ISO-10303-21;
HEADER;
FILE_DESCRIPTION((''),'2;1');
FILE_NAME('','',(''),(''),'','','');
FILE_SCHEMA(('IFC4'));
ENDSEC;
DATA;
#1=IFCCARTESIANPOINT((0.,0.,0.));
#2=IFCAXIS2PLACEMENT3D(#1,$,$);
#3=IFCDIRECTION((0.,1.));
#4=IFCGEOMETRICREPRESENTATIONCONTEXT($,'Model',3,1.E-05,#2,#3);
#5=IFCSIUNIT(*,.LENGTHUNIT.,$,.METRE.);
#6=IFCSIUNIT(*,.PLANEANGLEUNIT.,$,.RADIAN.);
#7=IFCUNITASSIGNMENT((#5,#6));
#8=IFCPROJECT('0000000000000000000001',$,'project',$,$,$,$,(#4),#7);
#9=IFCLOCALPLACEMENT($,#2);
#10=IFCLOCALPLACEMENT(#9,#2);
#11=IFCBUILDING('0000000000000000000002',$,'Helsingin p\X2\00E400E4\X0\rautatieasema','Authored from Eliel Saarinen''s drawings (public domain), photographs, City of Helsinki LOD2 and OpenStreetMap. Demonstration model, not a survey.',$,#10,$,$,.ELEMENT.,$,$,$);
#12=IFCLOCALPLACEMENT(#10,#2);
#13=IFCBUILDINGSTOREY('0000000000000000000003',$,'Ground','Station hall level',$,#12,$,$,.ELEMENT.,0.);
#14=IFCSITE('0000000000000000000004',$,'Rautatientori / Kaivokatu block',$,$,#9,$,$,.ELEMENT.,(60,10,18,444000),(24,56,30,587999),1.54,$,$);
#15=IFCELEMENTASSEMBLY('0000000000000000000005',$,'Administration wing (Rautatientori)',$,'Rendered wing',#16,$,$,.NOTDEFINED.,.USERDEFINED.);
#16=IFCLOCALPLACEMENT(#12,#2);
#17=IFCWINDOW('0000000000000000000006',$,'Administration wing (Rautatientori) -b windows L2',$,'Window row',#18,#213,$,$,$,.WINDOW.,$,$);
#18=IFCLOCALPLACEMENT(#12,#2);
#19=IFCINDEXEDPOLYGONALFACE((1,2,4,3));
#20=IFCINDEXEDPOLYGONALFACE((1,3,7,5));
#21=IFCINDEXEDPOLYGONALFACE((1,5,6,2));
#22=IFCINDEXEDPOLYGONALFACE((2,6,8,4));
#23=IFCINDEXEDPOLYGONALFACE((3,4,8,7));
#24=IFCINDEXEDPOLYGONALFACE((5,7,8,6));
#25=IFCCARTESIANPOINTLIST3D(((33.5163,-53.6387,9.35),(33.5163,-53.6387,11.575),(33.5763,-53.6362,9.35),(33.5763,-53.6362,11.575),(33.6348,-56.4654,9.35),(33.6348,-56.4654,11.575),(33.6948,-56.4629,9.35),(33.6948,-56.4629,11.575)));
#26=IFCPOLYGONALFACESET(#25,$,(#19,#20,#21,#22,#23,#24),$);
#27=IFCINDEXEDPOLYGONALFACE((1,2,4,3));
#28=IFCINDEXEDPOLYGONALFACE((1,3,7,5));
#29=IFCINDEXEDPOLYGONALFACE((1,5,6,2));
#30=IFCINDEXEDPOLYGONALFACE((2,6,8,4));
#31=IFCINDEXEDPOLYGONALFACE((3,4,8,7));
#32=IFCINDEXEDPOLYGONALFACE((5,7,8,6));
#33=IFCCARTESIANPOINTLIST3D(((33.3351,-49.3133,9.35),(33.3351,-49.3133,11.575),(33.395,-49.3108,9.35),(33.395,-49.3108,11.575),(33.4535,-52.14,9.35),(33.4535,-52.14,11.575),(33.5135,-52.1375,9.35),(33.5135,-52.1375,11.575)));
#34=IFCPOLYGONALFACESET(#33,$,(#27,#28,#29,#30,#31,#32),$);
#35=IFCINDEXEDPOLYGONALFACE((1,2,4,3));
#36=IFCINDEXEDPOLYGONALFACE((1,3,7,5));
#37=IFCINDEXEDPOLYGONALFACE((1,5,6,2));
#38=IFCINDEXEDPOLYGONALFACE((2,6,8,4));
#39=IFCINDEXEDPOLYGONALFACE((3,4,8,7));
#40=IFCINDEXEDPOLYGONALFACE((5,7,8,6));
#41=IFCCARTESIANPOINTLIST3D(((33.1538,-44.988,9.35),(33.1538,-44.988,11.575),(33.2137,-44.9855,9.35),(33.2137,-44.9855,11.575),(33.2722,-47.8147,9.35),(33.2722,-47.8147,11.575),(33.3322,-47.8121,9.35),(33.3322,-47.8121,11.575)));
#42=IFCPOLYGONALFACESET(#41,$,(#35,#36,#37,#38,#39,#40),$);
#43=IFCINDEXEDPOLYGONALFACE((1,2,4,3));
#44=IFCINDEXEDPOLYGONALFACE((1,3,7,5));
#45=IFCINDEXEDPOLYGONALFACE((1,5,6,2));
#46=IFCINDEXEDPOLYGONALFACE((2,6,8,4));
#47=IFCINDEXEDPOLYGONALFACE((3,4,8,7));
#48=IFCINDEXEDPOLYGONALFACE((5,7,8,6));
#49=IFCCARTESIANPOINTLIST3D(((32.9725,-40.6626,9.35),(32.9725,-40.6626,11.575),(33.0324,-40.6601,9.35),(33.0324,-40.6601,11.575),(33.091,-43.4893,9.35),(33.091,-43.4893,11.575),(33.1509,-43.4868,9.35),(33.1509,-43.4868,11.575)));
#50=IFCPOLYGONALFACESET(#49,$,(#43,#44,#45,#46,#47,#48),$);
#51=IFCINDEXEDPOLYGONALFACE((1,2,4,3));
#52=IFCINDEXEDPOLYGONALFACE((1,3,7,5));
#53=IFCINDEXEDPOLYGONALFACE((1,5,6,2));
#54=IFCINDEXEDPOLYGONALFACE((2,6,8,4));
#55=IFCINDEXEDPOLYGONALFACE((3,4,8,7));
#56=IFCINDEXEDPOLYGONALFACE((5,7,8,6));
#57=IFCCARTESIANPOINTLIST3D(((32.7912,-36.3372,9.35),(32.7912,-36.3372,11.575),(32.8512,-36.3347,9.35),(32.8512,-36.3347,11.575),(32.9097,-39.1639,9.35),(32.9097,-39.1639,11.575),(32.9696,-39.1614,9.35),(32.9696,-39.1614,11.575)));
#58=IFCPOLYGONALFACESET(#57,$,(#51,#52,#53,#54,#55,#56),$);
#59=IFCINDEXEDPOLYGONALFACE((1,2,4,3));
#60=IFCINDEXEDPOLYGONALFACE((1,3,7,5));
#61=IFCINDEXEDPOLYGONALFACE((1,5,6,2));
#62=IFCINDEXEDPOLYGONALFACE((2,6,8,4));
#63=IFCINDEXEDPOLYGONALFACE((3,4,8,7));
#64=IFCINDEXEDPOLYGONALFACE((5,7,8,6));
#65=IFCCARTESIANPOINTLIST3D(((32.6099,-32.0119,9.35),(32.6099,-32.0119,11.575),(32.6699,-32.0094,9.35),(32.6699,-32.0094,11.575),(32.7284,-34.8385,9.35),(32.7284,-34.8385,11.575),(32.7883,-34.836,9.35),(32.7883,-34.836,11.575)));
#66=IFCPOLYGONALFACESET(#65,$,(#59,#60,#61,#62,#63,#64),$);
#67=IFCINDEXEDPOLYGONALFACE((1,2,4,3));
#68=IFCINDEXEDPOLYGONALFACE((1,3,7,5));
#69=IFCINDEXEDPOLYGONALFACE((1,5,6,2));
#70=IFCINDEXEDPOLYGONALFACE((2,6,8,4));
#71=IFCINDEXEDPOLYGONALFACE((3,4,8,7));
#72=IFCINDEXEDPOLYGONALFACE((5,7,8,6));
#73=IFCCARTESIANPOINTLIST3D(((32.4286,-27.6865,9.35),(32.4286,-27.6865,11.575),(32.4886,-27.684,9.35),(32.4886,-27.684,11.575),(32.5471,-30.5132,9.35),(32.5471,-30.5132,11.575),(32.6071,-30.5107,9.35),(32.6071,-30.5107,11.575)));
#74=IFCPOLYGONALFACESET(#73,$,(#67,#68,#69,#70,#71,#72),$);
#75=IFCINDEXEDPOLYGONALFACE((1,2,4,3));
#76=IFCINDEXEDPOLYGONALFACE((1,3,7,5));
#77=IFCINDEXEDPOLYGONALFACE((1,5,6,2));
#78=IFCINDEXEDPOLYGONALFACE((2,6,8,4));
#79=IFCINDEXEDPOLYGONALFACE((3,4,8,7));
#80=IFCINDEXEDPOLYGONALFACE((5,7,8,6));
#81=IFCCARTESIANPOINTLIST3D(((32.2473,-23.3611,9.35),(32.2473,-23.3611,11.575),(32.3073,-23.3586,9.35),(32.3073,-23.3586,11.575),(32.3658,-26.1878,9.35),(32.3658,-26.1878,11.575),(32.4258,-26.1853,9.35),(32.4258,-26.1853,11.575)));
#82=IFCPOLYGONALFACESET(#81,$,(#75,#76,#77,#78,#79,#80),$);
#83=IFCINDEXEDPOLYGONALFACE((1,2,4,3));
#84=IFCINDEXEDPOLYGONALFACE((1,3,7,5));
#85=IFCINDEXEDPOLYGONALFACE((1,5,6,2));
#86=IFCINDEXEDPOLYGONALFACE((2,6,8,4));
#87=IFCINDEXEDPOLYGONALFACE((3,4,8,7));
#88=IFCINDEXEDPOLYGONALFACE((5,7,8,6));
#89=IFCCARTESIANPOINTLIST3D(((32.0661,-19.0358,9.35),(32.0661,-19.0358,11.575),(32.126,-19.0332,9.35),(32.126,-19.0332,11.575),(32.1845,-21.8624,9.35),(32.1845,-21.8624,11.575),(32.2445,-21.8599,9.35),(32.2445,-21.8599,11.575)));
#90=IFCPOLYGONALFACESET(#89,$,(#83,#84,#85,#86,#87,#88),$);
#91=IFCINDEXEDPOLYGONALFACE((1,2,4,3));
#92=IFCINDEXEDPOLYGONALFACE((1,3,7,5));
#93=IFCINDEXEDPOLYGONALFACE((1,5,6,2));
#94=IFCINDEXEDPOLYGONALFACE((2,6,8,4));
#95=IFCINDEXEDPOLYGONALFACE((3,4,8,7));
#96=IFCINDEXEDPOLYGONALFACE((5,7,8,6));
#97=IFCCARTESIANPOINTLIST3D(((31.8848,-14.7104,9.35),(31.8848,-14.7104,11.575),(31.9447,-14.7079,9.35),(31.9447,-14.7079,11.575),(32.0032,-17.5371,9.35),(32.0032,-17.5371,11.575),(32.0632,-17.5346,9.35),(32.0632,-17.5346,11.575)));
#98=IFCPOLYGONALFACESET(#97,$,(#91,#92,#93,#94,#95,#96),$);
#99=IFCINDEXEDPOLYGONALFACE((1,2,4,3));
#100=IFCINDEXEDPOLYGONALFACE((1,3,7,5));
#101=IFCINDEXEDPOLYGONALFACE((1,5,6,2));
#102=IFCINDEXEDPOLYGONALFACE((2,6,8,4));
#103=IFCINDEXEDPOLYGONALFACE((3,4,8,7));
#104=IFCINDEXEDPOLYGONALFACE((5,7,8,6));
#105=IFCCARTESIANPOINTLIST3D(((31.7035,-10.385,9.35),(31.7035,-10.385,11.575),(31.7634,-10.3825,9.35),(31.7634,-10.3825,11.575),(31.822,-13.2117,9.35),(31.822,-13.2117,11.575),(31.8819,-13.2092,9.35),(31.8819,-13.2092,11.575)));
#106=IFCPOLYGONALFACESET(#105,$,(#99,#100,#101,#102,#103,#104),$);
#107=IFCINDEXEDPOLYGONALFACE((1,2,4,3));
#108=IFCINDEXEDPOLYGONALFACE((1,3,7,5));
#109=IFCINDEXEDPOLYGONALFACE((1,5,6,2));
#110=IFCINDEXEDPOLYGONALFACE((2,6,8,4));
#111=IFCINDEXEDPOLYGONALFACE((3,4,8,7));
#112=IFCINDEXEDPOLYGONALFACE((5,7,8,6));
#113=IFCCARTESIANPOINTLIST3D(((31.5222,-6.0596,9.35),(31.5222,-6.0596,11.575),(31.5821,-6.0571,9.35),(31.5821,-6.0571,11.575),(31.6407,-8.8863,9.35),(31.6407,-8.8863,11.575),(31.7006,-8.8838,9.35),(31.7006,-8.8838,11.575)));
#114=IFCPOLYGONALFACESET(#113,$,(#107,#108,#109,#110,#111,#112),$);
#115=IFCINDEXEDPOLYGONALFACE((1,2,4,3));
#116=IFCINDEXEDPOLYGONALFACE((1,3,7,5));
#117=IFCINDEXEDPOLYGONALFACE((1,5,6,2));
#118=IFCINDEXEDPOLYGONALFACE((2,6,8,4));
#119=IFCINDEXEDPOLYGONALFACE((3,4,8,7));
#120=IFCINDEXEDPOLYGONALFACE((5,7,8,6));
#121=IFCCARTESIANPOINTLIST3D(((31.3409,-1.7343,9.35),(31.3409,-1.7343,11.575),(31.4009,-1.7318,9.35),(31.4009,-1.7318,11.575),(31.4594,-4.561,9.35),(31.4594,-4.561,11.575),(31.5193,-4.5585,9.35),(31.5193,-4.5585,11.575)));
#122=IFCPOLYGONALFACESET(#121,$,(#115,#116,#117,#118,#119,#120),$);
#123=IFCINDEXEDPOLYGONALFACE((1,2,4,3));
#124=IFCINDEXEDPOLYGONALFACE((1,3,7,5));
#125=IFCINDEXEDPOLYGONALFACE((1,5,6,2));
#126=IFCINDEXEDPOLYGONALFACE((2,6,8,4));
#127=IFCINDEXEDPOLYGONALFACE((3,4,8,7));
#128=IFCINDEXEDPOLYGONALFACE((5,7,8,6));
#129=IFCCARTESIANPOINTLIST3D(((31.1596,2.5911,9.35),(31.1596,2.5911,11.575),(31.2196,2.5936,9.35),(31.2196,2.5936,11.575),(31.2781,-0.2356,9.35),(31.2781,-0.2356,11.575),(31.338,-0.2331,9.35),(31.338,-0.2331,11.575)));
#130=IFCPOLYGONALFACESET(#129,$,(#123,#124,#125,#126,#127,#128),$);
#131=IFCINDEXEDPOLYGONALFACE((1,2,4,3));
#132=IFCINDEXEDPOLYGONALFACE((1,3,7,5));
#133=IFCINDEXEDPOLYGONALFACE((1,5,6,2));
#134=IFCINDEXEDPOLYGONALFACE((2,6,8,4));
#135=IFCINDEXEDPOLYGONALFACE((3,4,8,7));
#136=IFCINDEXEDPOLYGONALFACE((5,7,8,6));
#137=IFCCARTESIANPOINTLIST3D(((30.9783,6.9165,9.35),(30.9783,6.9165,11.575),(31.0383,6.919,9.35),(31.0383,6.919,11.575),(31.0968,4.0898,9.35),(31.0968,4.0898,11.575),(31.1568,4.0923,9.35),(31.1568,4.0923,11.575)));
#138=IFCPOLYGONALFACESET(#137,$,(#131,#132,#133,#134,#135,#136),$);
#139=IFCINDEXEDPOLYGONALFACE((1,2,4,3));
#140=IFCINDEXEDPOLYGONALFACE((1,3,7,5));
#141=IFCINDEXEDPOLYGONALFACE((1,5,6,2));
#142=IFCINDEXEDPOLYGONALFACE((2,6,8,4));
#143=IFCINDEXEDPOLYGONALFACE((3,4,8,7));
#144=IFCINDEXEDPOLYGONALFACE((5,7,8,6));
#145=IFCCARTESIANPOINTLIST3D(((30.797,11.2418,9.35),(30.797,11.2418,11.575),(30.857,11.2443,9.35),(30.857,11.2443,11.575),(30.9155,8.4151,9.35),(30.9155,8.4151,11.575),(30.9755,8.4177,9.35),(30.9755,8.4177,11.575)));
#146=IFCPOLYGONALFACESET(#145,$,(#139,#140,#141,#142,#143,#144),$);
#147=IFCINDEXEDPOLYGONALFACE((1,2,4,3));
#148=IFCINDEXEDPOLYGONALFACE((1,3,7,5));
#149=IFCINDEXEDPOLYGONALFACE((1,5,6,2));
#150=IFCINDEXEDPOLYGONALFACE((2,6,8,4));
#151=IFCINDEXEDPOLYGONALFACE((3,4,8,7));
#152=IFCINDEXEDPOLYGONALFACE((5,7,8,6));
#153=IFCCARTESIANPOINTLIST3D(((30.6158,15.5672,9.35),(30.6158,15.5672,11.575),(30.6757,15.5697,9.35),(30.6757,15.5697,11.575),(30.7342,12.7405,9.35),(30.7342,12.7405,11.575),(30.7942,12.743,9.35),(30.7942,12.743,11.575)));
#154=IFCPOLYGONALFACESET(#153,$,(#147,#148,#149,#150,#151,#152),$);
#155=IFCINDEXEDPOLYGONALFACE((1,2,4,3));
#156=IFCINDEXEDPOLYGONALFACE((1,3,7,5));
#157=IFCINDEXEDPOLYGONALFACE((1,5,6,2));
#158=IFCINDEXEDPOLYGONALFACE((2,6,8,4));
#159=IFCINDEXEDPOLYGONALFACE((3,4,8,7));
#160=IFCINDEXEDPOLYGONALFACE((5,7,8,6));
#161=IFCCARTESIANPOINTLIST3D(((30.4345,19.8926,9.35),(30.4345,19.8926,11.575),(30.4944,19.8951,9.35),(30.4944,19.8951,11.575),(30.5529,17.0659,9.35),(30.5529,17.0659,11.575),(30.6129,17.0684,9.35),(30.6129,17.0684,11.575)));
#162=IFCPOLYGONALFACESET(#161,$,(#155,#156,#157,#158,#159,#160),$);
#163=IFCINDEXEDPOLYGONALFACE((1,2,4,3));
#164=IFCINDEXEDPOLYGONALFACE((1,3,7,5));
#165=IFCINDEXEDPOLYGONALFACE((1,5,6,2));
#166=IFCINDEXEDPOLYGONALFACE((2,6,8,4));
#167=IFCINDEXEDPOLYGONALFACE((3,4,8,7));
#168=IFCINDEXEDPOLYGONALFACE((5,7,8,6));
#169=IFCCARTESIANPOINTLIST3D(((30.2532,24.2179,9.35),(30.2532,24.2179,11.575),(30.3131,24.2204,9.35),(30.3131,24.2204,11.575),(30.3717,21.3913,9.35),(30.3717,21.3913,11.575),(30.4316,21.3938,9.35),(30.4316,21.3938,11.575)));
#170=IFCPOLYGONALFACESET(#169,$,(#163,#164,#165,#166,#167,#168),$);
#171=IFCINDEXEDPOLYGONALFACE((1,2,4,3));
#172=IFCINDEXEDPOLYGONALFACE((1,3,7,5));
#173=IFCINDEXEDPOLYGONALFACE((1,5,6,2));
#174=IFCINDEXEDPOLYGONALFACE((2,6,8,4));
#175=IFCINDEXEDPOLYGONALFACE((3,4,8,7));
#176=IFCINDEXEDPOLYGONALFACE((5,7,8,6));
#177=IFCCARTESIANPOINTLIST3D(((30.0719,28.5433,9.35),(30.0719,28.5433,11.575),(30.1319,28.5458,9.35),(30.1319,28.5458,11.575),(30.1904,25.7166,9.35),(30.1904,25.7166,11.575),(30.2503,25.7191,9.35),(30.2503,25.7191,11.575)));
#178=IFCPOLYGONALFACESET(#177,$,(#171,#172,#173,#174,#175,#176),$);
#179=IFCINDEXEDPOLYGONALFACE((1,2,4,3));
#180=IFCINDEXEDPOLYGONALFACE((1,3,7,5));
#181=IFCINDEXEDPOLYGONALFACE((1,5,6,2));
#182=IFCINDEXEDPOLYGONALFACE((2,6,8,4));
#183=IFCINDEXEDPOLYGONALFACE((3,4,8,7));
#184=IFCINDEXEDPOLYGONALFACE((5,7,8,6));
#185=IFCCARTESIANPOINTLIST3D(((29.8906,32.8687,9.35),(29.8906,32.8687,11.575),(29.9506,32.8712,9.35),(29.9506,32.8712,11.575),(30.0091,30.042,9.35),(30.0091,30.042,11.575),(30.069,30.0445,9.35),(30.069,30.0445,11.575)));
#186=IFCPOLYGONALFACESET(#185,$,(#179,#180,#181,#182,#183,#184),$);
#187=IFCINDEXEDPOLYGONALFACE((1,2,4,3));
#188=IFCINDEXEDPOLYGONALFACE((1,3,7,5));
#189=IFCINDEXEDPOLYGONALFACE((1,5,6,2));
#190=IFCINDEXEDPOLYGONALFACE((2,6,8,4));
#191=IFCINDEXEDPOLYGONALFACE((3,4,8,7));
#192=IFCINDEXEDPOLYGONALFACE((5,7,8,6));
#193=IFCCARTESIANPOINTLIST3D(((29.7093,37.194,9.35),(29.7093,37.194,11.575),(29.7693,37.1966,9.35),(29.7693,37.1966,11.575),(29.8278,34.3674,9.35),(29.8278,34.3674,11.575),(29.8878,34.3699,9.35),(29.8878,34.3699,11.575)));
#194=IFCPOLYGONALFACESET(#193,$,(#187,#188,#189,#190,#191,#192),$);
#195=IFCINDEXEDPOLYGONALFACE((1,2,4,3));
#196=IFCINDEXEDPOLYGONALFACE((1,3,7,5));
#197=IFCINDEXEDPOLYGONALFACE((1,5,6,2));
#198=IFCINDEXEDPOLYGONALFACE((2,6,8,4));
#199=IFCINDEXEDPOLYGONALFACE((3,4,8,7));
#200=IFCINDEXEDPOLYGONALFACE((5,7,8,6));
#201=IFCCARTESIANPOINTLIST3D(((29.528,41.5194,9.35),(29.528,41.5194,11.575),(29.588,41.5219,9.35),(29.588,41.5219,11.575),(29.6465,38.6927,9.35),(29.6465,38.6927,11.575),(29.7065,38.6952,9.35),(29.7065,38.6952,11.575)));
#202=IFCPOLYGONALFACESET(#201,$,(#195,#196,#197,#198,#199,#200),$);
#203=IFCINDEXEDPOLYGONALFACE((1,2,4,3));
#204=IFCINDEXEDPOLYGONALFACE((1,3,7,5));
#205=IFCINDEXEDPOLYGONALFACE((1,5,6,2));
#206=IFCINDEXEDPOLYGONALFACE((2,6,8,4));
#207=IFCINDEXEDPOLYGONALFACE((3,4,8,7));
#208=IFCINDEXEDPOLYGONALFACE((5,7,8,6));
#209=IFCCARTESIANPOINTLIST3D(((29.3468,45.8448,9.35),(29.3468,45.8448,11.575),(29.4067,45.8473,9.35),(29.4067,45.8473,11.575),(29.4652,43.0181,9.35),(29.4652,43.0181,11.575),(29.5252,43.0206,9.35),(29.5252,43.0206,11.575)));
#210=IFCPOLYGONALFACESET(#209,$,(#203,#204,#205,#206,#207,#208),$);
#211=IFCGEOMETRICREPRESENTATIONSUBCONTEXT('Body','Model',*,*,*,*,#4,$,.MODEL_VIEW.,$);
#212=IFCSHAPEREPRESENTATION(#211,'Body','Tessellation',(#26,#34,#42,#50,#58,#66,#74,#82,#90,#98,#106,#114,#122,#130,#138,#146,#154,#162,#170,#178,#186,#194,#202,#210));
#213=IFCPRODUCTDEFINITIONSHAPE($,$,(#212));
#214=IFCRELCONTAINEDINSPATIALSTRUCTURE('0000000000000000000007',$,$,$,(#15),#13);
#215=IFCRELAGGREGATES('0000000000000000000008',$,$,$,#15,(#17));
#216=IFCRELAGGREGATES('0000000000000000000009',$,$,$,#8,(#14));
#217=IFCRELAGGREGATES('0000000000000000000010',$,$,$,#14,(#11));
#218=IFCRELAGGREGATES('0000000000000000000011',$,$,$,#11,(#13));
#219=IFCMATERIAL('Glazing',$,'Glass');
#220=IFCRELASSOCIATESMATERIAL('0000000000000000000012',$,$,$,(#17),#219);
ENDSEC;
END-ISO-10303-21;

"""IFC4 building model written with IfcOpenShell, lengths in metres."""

from ifc_helpers import new_model, si_unit, direction, frame, frame_2d, origin, place, context, subcontext, project, spatial, rectangle, extrude, material, element, aggregate, save


model = new_model("IFC4")

# Units and contexts
model_context = context("Model", 3, precision=1e-05, world=origin(), true_north=direction((0.0, 1.0)))
body_context = subcontext(model_context, "Body", "Model", "MODEL_VIEW")
ifc_project = project(units=[si_unit("LENGTHUNIT", "METRE"), si_unit("PLANEANGLEUNIT", "RADIAN")], contexts=[model_context])

# Site, building, storey
site_placement = place(None, origin())
site = spatial("IfcSite", under=ifc_project, at=site_placement, Name="Rautatientori / Kaivokatu block", CompositionType="ELEMENT", RefLatitude=(60, 10, 18, 444000), RefLongitude=(24, 56, 30, 587999), RefElevation=1.54)
building_placement = place(site_placement, origin())
building = spatial("IfcBuilding", under=site, at=building_placement, Name="Helsingin päärautatieasema", Description="Authored from Eliel Saarinen's drawings (public domain), photographs, City of Helsinki LOD2 and OpenStreetMap. Demonstration model, not a survey.", CompositionType="ELEMENT")
storey_placement = place(building_placement, origin())
storey = spatial("IfcBuildingStorey", under=building, at=storey_placement, Name="Ground", Description="Station hall level", CompositionType="ELEMENT", Elevation=0.0)

# Element assembly, window
assembly_placement = place(building_placement, origin())
assembly = element("IfcElementAssembly", 1, at=assembly_placement, inside=storey, Name="Administration wing (Rautatientori)", ObjectType="Rendered wing", AssemblyPlace="NOTDEFINED", PredefinedType="USERDEFINED")
ifc_material_1 = material(Name="Glazing", Category="Glass")
window_1_placement = place(building_placement, origin())
window_1 = element("IfcWindow", 2, at=window_1_placement, material=ifc_material_1, Name="Administration wing (Rautatientori) -b windows L2", ObjectType="Window row", PredefinedType="WINDOW", context=body_context, shape_type="SweptSolid", body=[
    extrude(rectangle(XDim=2.8292, YDim=0.06, at=frame_2d((0.0, 0.0), x_axis=(-0.041876, 0.999123))), frame((33.6056, -55.0508, 9.35)), (0.0, 0.0, 1.0), 2.225),
    extrude(rectangle(XDim=2.8292, YDim=0.06, at=frame_2d((0.0, 0.0), x_axis=(-0.041876, 0.999123))), frame((33.4243, -50.7254, 9.35)), (0.0, 0.0, 1.0), 2.225),
    extrude(rectangle(XDim=2.8292, YDim=0.06, at=frame_2d((0.0, 0.0), x_axis=(-0.041876, 0.999123))), frame((33.243, -46.4001, 9.35)), (0.0, 0.0, 1.0), 2.225),
    extrude(rectangle(XDim=2.8292, YDim=0.06, at=frame_2d((0.0, 0.0), x_axis=(-0.041876, 0.999123))), frame((33.0617, -42.0747, 9.35)), (0.0, 0.0, 1.0), 2.225),
    extrude(rectangle(XDim=2.8292, YDim=0.06, at=frame_2d((0.0, 0.0), x_axis=(-0.041876, 0.999123))), frame((32.8804, -37.7493, 9.35)), (0.0, 0.0, 1.0), 2.225),
    extrude(rectangle(XDim=2.8292, YDim=0.06, at=frame_2d((0.0, 0.0), x_axis=(-0.041876, 0.999123))), frame((32.6991, -33.4239, 9.35)), (0.0, 0.0, 1.0), 2.225),
    extrude(rectangle(XDim=2.8292, YDim=0.06, at=frame_2d((0.0, 0.0), x_axis=(-0.041876, 0.999123))), frame((32.5178, -29.0986, 9.35)), (0.0, 0.0, 1.0), 2.225),
    extrude(rectangle(XDim=2.8292, YDim=0.06, at=frame_2d((0.0, 0.0), x_axis=(-0.041876, 0.999123))), frame((32.3366, -24.7732, 9.35)), (0.0, 0.0, 1.0), 2.225),
    extrude(rectangle(XDim=2.8292, YDim=0.06, at=frame_2d((0.0, 0.0), x_axis=(-0.041876, 0.999123))), frame((32.1553, -20.4478, 9.35)), (0.0, 0.0, 1.0), 2.225),
    extrude(rectangle(XDim=2.8292, YDim=0.06, at=frame_2d((0.0, 0.0), x_axis=(-0.041876, 0.999123))), frame((31.974, -16.1225, 9.35)), (0.0, 0.0, 1.0), 2.225),
    extrude(rectangle(XDim=2.8292, YDim=0.06, at=frame_2d((0.0, 0.0), x_axis=(-0.041876, 0.999123))), frame((31.7927, -11.7971, 9.35)), (0.0, 0.0, 1.0), 2.225),
    extrude(rectangle(XDim=2.8292, YDim=0.06, at=frame_2d((0.0, 0.0), x_axis=(-0.041876, 0.999123))), frame((31.6114, -7.4717, 9.35)), (0.0, 0.0, 1.0), 2.225),
    extrude(rectangle(XDim=2.8292, YDim=0.06, at=frame_2d((0.0, 0.0), x_axis=(-0.041876, 0.999123))), frame((31.4301, -3.1464, 9.35)), (0.0, 0.0, 1.0), 2.225),
    extrude(rectangle(XDim=2.8292, YDim=0.06, at=frame_2d((0.0, 0.0), x_axis=(-0.041876, 0.999123))), frame((31.2488, 1.179, 9.35)), (0.0, 0.0, 1.0), 2.225),
    extrude(rectangle(XDim=2.8292, YDim=0.06, at=frame_2d((0.0, 0.0), x_axis=(-0.041876, 0.999123))), frame((31.0675, 5.5044, 9.35)), (0.0, 0.0, 1.0), 2.225),
    extrude(rectangle(XDim=2.8292, YDim=0.06, at=frame_2d((0.0, 0.0), x_axis=(-0.041876, 0.999123))), frame((30.8863, 9.8297, 9.35)), (0.0, 0.0, 1.0), 2.225),
    extrude(rectangle(XDim=2.8292, YDim=0.06, at=frame_2d((0.0, 0.0), x_axis=(-0.041876, 0.999123))), frame((30.705, 14.1551, 9.35)), (0.0, 0.0, 1.0), 2.225),
    extrude(rectangle(XDim=2.8292, YDim=0.06, at=frame_2d((0.0, 0.0), x_axis=(-0.041876, 0.999123))), frame((30.5237, 18.4805, 9.35)), (0.0, 0.0, 1.0), 2.225),
    extrude(rectangle(XDim=2.8292, YDim=0.06, at=frame_2d((0.0, 0.0), x_axis=(-0.041876, 0.999123))), frame((30.3424, 22.8059, 9.35)), (0.0, 0.0, 1.0), 2.225),
    extrude(rectangle(XDim=2.8292, YDim=0.06, at=frame_2d((0.0, 0.0), x_axis=(-0.041876, 0.999123))), frame((30.1611, 27.1312, 9.35)), (0.0, 0.0, 1.0), 2.225),
    extrude(rectangle(XDim=2.8292, YDim=0.06, at=frame_2d((0.0, 0.0), x_axis=(-0.041876, 0.999123))), frame((29.9798, 31.4566, 9.35)), (0.0, 0.0, 1.0), 2.225),
    extrude(rectangle(XDim=2.8292, YDim=0.06, at=frame_2d((0.0, 0.0), x_axis=(-0.041876, 0.999123))), frame((29.7985, 35.782, 9.35)), (0.0, 0.0, 1.0), 2.225),
    extrude(rectangle(XDim=2.8292, YDim=0.06, at=frame_2d((0.0, 0.0), x_axis=(-0.041876, 0.999123))), frame((29.6173, 40.1073, 9.35)), (0.0, 0.0, 1.0), 2.225),
    extrude(rectangle(XDim=2.8292, YDim=0.06, at=frame_2d((0.0, 0.0), x_axis=(-0.041876, 0.999123))), frame((29.436, 44.4327, 9.35)), (0.0, 0.0, 1.0), 2.225),
])
aggregate(assembly, [window_1])

save(model, "model.ifc")
